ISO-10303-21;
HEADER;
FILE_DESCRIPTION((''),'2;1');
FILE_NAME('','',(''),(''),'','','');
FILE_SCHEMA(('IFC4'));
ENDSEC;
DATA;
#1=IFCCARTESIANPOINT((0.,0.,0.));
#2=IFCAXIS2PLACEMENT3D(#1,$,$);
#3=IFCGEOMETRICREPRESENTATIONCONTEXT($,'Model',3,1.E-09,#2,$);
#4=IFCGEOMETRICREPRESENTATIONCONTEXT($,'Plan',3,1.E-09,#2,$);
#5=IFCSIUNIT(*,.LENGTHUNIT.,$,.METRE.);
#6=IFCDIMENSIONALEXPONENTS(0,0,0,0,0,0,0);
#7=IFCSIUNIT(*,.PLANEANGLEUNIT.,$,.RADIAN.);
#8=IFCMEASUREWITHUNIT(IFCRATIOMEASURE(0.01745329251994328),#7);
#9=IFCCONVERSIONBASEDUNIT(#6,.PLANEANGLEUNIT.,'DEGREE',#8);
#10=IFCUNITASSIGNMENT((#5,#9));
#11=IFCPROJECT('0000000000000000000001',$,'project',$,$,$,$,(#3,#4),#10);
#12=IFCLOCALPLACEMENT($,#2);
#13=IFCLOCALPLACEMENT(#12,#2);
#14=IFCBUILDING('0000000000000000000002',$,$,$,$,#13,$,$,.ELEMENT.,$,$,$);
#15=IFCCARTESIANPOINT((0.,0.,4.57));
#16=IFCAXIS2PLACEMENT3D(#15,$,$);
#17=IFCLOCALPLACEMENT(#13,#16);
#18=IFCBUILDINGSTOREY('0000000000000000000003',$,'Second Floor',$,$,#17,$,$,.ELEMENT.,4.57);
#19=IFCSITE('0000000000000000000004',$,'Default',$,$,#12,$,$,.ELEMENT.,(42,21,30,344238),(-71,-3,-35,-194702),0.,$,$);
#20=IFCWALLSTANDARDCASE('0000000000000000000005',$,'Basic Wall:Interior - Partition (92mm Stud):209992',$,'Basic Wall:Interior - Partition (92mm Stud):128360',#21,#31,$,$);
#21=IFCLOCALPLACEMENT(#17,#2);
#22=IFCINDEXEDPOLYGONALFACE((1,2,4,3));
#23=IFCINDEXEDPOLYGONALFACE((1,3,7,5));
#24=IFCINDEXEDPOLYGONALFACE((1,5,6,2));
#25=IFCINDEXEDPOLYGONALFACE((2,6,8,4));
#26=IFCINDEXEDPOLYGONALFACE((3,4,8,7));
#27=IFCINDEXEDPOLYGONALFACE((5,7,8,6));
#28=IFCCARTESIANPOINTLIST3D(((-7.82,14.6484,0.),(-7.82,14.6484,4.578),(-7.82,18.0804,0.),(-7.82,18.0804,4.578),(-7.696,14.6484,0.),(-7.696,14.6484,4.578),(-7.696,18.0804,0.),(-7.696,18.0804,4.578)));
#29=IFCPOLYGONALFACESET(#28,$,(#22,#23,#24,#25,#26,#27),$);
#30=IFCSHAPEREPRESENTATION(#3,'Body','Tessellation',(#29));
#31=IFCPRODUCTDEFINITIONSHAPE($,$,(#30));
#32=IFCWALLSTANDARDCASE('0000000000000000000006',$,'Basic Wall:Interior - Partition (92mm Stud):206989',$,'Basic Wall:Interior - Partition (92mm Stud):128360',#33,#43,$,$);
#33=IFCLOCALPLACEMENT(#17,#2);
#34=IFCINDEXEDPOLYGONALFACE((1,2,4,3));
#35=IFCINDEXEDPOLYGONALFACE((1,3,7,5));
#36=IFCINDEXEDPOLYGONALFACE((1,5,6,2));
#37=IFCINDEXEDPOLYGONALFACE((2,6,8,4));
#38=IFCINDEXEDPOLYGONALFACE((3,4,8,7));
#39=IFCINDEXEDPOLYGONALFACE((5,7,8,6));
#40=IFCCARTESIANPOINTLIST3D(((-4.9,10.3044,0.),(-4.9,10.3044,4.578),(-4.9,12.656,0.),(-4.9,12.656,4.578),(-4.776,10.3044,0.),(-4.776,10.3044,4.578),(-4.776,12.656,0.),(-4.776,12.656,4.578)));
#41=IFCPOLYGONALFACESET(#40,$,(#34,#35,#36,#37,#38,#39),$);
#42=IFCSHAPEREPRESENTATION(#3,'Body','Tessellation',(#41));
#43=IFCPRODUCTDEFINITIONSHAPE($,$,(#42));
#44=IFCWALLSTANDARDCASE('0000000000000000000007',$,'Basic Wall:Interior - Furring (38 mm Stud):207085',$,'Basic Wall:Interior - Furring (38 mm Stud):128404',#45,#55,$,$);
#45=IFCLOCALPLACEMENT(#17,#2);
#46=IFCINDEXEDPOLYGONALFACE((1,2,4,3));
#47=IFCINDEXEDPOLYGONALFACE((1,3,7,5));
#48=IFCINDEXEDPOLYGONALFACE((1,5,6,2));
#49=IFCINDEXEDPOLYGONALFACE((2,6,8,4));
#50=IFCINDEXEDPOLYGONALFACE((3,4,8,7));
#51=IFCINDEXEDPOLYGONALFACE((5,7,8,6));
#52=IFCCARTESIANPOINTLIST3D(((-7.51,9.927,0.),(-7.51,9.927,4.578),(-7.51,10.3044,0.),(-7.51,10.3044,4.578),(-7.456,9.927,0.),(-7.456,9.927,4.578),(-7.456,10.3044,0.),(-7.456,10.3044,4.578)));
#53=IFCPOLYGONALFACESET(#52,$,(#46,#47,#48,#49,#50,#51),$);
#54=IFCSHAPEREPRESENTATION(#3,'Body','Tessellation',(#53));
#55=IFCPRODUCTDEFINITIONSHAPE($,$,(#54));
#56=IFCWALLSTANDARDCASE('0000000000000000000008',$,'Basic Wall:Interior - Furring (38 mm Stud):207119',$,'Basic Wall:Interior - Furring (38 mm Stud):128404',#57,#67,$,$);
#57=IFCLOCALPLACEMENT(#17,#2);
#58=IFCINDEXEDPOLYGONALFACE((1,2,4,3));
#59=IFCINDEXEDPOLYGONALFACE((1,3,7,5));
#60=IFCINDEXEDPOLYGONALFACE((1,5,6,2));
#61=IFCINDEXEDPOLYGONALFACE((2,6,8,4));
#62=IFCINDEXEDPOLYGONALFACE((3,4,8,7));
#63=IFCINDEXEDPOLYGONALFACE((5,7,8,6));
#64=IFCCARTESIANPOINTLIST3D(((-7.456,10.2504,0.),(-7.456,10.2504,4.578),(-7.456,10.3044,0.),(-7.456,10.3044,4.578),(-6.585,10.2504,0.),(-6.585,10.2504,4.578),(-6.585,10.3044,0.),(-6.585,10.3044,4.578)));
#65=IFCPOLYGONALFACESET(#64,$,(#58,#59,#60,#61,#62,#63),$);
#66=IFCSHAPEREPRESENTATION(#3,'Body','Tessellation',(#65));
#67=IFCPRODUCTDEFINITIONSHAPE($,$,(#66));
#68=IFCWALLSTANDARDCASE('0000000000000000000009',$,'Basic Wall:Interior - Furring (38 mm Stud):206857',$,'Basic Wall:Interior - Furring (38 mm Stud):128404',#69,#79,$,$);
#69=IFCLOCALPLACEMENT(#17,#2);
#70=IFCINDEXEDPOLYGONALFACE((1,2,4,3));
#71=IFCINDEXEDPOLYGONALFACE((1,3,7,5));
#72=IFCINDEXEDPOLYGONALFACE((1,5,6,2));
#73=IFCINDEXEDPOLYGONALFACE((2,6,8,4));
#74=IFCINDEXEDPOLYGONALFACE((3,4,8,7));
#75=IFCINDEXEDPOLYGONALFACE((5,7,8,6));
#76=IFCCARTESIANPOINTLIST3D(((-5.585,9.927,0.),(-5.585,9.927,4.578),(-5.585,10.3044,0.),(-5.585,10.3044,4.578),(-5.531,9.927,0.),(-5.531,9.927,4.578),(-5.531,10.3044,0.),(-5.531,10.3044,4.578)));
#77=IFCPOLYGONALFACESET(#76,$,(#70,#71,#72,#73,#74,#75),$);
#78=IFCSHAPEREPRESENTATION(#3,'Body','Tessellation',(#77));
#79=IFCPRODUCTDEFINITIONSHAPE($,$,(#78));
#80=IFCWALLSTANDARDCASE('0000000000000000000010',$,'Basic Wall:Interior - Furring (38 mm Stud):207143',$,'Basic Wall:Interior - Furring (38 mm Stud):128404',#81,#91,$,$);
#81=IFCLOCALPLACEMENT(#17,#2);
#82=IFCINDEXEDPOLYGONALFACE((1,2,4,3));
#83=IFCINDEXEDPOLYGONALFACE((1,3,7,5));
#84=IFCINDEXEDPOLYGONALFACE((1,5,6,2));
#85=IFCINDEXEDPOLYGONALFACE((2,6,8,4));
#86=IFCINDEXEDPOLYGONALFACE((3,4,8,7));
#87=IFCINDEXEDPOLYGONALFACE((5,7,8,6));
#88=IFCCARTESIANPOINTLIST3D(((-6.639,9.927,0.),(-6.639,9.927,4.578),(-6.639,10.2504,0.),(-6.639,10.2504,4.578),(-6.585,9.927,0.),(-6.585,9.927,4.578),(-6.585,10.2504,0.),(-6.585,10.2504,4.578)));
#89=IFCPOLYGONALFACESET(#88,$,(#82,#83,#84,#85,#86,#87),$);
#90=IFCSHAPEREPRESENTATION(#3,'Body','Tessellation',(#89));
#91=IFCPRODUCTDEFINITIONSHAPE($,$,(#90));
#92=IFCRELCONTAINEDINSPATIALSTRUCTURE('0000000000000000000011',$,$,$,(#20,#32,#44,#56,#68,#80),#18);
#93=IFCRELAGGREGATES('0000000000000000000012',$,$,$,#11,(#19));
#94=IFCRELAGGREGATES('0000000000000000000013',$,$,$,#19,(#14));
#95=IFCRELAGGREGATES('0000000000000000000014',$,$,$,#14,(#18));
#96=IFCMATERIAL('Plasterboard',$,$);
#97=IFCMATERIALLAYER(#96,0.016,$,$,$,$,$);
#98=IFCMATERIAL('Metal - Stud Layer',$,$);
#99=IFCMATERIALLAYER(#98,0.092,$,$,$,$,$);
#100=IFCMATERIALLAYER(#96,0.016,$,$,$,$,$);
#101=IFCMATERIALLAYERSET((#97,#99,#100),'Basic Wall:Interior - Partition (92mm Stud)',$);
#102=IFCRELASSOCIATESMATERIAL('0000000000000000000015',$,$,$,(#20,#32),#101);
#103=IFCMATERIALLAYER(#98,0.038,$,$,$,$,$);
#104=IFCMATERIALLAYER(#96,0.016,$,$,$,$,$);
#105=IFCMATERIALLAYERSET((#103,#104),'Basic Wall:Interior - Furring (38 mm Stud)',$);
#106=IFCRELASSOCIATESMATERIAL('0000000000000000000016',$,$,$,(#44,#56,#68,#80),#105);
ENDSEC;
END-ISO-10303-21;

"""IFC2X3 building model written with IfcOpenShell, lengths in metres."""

from ifc_helpers import new_model, entity, si_unit, converted_unit, frame, frame_2d, origin, place, context, project, spatial, rectangle, extrude, material, layer, layer_set, layer_usage, element, save


model = new_model("IFC2X3")

# Units and contexts
model_context = context("Model", 3, precision=1e-09, world=origin())
plan_context = context("Plan", 3, precision=1e-09, world=origin())
ifc_project = project(units=[si_unit("LENGTHUNIT", "METRE"), converted_unit("PLANEANGLEUNIT", "DEGREE", entity("IfcRatioMeasure", 0.01745329251994328), si_unit("PLANEANGLEUNIT", "RADIAN"), dimensions=[0, 0, 0, 0, 0, 0, 0])], contexts=[model_context, plan_context])

# Site, building, storey
site_placement = place(None, origin())
site = spatial("IfcSite", under=ifc_project, at=site_placement, Name="Default", CompositionType="ELEMENT", RefLatitude=(42, 21, 30, 344238), RefLongitude=(-71, -3, -35, -194702), RefElevation=0.0)
building_placement = place(site_placement, origin())
building = spatial("IfcBuilding", under=site, at=building_placement, CompositionType="ELEMENT")
storey_placement = place(building_placement, frame((0.0, 0.0, 4.57)))
storey = spatial("IfcBuildingStorey", under=building, at=storey_placement, Name="Second Floor", CompositionType="ELEMENT", Elevation=4.57)

# Shared definitions
ifc_material_1 = material(Name="Plasterboard")
ifc_layer_1 = layer(ifc_material_1, 0.016)
ifc_material_2 = material(Name="Metal - Stud Layer")
ifc_layer_2 = layer(ifc_material_2, 0.092)
ifc_layer_3 = layer(ifc_material_1, 0.016)
ifc_layer_set_1 = layer_set([ifc_layer_1, ifc_layer_2, ifc_layer_3], Name="Basic Wall:Interior - Partition (92mm Stud)")
ifc_layer_usage_1 = layer_usage(ifc_layer_set_1, "AXIS2", "NEGATIVE", 0.062)

# Walls
ifc_layer_4 = layer(ifc_material_2, 0.038)
ifc_layer_5 = layer(ifc_material_1, 0.016)
ifc_layer_set_2 = layer_set([ifc_layer_4, ifc_layer_5], Name="Basic Wall:Interior - Furring (38 mm Stud)")
ifc_layer_usage_2 = layer_usage(ifc_layer_set_2, "AXIS2", "POSITIVE", -0.027)
wall_1_placement = place(storey_placement, frame((-7.758, 14.6484, 0.0), z_axis=(0.0, 0.0, 1.0), x_axis=(0.0, 1.0, 0.0)))
element("IfcWallStandardCase", 1, at=wall_1_placement, inside=storey, material=ifc_layer_usage_1, Name="Basic Wall:Interior - Partition (92mm Stud):209992", ObjectType="Basic Wall:Interior - Partition (92mm Stud):128360", context=model_context, shape_type="SweptSolid", body=[
    extrude(rectangle(XDim=3.432, YDim=0.124, at=frame_2d((1.716, 0.0), x_axis=(-1.0, 0.0))), origin(), (0.0, 0.0, 1.0), 4.578),
])
wall_2_placement = place(storey_placement, frame((-4.838, 10.3044, 0.0), z_axis=(0.0, 0.0, 1.0), x_axis=(0.0, 1.0, 0.0)))
element("IfcWallStandardCase", 2, at=wall_2_placement, inside=storey, material=ifc_layer_usage_1, Name="Basic Wall:Interior - Partition (92mm Stud):206989", ObjectType="Basic Wall:Interior - Partition (92mm Stud):128360", context=model_context, shape_type="SweptSolid", body=[
    extrude(rectangle(XDim=2.3516, YDim=0.124, at=frame_2d((1.1758, 0.0), x_axis=(-1.0, 0.0))), origin(), (0.0, 0.0, 1.0), 4.578),
])
wall_3_placement = place(storey_placement, frame((-7.483, 9.927, 0.0), z_axis=(0.0, 0.0, 1.0), x_axis=(0.0, 1.0, 0.0)))
element("IfcWallStandardCase", 3, at=wall_3_placement, inside=storey, material=ifc_layer_usage_2, Name="Basic Wall:Interior - Furring (38 mm Stud):207085", ObjectType="Basic Wall:Interior - Furring (38 mm Stud):128404", context=model_context, shape_type="SweptSolid", body=[
    extrude(rectangle(XDim=0.3774, YDim=0.054, at=frame_2d((0.1887, 0.0), x_axis=(-1.0, 0.0))), origin(), (0.0, 0.0, 1.0), 4.578),
])
wall_4_placement = place(storey_placement, frame((-7.456, 10.2774, 0.0)))
element("IfcWallStandardCase", 4, at=wall_4_placement, inside=storey, material=ifc_layer_usage_2, Name="Basic Wall:Interior - Furring (38 mm Stud):207119", ObjectType="Basic Wall:Interior - Furring (38 mm Stud):128404", context=model_context, shape_type="SweptSolid", body=[
    extrude(rectangle(XDim=0.871, YDim=0.054, at=frame_2d((0.4355, 0.0), x_axis=(-1.0, 0.0))), origin(), (0.0, 0.0, 1.0), 4.578),
])
wall_5_placement = place(storey_placement, frame((-5.558, 9.927, 0.0), z_axis=(0.0, 0.0, 1.0), x_axis=(0.0, 1.0, 0.0)))
element("IfcWallStandardCase", 5, at=wall_5_placement, inside=storey, material=ifc_layer_usage_2, Name="Basic Wall:Interior - Furring (38 mm Stud):206857", ObjectType="Basic Wall:Interior - Furring (38 mm Stud):128404", context=model_context, shape_type="SweptSolid", body=[
    extrude(rectangle(XDim=0.3774, YDim=0.054, at=frame_2d((0.1887, 0.0), x_axis=(-1.0, 0.0))), origin(), (0.0, 0.0, 1.0), 4.578),
])
wall_6_placement = place(storey_placement, frame((-6.612, 10.2504, 0.0), z_axis=(0.0, 0.0, 1.0), x_axis=(0.0, -1.0, 0.0)))
element("IfcWallStandardCase", 6, at=wall_6_placement, inside=storey, material=ifc_layer_usage_2, Name="Basic Wall:Interior - Furring (38 mm Stud):207143", ObjectType="Basic Wall:Interior - Furring (38 mm Stud):128404", context=model_context, shape_type="SweptSolid", body=[
    extrude(rectangle(XDim=0.3234, YDim=0.054, at=frame_2d((0.1617, 0.0), x_axis=(-1.0, 0.0))), origin(), (0.0, 0.0, 1.0), 4.578),
])

save(model, "model.ifc")
